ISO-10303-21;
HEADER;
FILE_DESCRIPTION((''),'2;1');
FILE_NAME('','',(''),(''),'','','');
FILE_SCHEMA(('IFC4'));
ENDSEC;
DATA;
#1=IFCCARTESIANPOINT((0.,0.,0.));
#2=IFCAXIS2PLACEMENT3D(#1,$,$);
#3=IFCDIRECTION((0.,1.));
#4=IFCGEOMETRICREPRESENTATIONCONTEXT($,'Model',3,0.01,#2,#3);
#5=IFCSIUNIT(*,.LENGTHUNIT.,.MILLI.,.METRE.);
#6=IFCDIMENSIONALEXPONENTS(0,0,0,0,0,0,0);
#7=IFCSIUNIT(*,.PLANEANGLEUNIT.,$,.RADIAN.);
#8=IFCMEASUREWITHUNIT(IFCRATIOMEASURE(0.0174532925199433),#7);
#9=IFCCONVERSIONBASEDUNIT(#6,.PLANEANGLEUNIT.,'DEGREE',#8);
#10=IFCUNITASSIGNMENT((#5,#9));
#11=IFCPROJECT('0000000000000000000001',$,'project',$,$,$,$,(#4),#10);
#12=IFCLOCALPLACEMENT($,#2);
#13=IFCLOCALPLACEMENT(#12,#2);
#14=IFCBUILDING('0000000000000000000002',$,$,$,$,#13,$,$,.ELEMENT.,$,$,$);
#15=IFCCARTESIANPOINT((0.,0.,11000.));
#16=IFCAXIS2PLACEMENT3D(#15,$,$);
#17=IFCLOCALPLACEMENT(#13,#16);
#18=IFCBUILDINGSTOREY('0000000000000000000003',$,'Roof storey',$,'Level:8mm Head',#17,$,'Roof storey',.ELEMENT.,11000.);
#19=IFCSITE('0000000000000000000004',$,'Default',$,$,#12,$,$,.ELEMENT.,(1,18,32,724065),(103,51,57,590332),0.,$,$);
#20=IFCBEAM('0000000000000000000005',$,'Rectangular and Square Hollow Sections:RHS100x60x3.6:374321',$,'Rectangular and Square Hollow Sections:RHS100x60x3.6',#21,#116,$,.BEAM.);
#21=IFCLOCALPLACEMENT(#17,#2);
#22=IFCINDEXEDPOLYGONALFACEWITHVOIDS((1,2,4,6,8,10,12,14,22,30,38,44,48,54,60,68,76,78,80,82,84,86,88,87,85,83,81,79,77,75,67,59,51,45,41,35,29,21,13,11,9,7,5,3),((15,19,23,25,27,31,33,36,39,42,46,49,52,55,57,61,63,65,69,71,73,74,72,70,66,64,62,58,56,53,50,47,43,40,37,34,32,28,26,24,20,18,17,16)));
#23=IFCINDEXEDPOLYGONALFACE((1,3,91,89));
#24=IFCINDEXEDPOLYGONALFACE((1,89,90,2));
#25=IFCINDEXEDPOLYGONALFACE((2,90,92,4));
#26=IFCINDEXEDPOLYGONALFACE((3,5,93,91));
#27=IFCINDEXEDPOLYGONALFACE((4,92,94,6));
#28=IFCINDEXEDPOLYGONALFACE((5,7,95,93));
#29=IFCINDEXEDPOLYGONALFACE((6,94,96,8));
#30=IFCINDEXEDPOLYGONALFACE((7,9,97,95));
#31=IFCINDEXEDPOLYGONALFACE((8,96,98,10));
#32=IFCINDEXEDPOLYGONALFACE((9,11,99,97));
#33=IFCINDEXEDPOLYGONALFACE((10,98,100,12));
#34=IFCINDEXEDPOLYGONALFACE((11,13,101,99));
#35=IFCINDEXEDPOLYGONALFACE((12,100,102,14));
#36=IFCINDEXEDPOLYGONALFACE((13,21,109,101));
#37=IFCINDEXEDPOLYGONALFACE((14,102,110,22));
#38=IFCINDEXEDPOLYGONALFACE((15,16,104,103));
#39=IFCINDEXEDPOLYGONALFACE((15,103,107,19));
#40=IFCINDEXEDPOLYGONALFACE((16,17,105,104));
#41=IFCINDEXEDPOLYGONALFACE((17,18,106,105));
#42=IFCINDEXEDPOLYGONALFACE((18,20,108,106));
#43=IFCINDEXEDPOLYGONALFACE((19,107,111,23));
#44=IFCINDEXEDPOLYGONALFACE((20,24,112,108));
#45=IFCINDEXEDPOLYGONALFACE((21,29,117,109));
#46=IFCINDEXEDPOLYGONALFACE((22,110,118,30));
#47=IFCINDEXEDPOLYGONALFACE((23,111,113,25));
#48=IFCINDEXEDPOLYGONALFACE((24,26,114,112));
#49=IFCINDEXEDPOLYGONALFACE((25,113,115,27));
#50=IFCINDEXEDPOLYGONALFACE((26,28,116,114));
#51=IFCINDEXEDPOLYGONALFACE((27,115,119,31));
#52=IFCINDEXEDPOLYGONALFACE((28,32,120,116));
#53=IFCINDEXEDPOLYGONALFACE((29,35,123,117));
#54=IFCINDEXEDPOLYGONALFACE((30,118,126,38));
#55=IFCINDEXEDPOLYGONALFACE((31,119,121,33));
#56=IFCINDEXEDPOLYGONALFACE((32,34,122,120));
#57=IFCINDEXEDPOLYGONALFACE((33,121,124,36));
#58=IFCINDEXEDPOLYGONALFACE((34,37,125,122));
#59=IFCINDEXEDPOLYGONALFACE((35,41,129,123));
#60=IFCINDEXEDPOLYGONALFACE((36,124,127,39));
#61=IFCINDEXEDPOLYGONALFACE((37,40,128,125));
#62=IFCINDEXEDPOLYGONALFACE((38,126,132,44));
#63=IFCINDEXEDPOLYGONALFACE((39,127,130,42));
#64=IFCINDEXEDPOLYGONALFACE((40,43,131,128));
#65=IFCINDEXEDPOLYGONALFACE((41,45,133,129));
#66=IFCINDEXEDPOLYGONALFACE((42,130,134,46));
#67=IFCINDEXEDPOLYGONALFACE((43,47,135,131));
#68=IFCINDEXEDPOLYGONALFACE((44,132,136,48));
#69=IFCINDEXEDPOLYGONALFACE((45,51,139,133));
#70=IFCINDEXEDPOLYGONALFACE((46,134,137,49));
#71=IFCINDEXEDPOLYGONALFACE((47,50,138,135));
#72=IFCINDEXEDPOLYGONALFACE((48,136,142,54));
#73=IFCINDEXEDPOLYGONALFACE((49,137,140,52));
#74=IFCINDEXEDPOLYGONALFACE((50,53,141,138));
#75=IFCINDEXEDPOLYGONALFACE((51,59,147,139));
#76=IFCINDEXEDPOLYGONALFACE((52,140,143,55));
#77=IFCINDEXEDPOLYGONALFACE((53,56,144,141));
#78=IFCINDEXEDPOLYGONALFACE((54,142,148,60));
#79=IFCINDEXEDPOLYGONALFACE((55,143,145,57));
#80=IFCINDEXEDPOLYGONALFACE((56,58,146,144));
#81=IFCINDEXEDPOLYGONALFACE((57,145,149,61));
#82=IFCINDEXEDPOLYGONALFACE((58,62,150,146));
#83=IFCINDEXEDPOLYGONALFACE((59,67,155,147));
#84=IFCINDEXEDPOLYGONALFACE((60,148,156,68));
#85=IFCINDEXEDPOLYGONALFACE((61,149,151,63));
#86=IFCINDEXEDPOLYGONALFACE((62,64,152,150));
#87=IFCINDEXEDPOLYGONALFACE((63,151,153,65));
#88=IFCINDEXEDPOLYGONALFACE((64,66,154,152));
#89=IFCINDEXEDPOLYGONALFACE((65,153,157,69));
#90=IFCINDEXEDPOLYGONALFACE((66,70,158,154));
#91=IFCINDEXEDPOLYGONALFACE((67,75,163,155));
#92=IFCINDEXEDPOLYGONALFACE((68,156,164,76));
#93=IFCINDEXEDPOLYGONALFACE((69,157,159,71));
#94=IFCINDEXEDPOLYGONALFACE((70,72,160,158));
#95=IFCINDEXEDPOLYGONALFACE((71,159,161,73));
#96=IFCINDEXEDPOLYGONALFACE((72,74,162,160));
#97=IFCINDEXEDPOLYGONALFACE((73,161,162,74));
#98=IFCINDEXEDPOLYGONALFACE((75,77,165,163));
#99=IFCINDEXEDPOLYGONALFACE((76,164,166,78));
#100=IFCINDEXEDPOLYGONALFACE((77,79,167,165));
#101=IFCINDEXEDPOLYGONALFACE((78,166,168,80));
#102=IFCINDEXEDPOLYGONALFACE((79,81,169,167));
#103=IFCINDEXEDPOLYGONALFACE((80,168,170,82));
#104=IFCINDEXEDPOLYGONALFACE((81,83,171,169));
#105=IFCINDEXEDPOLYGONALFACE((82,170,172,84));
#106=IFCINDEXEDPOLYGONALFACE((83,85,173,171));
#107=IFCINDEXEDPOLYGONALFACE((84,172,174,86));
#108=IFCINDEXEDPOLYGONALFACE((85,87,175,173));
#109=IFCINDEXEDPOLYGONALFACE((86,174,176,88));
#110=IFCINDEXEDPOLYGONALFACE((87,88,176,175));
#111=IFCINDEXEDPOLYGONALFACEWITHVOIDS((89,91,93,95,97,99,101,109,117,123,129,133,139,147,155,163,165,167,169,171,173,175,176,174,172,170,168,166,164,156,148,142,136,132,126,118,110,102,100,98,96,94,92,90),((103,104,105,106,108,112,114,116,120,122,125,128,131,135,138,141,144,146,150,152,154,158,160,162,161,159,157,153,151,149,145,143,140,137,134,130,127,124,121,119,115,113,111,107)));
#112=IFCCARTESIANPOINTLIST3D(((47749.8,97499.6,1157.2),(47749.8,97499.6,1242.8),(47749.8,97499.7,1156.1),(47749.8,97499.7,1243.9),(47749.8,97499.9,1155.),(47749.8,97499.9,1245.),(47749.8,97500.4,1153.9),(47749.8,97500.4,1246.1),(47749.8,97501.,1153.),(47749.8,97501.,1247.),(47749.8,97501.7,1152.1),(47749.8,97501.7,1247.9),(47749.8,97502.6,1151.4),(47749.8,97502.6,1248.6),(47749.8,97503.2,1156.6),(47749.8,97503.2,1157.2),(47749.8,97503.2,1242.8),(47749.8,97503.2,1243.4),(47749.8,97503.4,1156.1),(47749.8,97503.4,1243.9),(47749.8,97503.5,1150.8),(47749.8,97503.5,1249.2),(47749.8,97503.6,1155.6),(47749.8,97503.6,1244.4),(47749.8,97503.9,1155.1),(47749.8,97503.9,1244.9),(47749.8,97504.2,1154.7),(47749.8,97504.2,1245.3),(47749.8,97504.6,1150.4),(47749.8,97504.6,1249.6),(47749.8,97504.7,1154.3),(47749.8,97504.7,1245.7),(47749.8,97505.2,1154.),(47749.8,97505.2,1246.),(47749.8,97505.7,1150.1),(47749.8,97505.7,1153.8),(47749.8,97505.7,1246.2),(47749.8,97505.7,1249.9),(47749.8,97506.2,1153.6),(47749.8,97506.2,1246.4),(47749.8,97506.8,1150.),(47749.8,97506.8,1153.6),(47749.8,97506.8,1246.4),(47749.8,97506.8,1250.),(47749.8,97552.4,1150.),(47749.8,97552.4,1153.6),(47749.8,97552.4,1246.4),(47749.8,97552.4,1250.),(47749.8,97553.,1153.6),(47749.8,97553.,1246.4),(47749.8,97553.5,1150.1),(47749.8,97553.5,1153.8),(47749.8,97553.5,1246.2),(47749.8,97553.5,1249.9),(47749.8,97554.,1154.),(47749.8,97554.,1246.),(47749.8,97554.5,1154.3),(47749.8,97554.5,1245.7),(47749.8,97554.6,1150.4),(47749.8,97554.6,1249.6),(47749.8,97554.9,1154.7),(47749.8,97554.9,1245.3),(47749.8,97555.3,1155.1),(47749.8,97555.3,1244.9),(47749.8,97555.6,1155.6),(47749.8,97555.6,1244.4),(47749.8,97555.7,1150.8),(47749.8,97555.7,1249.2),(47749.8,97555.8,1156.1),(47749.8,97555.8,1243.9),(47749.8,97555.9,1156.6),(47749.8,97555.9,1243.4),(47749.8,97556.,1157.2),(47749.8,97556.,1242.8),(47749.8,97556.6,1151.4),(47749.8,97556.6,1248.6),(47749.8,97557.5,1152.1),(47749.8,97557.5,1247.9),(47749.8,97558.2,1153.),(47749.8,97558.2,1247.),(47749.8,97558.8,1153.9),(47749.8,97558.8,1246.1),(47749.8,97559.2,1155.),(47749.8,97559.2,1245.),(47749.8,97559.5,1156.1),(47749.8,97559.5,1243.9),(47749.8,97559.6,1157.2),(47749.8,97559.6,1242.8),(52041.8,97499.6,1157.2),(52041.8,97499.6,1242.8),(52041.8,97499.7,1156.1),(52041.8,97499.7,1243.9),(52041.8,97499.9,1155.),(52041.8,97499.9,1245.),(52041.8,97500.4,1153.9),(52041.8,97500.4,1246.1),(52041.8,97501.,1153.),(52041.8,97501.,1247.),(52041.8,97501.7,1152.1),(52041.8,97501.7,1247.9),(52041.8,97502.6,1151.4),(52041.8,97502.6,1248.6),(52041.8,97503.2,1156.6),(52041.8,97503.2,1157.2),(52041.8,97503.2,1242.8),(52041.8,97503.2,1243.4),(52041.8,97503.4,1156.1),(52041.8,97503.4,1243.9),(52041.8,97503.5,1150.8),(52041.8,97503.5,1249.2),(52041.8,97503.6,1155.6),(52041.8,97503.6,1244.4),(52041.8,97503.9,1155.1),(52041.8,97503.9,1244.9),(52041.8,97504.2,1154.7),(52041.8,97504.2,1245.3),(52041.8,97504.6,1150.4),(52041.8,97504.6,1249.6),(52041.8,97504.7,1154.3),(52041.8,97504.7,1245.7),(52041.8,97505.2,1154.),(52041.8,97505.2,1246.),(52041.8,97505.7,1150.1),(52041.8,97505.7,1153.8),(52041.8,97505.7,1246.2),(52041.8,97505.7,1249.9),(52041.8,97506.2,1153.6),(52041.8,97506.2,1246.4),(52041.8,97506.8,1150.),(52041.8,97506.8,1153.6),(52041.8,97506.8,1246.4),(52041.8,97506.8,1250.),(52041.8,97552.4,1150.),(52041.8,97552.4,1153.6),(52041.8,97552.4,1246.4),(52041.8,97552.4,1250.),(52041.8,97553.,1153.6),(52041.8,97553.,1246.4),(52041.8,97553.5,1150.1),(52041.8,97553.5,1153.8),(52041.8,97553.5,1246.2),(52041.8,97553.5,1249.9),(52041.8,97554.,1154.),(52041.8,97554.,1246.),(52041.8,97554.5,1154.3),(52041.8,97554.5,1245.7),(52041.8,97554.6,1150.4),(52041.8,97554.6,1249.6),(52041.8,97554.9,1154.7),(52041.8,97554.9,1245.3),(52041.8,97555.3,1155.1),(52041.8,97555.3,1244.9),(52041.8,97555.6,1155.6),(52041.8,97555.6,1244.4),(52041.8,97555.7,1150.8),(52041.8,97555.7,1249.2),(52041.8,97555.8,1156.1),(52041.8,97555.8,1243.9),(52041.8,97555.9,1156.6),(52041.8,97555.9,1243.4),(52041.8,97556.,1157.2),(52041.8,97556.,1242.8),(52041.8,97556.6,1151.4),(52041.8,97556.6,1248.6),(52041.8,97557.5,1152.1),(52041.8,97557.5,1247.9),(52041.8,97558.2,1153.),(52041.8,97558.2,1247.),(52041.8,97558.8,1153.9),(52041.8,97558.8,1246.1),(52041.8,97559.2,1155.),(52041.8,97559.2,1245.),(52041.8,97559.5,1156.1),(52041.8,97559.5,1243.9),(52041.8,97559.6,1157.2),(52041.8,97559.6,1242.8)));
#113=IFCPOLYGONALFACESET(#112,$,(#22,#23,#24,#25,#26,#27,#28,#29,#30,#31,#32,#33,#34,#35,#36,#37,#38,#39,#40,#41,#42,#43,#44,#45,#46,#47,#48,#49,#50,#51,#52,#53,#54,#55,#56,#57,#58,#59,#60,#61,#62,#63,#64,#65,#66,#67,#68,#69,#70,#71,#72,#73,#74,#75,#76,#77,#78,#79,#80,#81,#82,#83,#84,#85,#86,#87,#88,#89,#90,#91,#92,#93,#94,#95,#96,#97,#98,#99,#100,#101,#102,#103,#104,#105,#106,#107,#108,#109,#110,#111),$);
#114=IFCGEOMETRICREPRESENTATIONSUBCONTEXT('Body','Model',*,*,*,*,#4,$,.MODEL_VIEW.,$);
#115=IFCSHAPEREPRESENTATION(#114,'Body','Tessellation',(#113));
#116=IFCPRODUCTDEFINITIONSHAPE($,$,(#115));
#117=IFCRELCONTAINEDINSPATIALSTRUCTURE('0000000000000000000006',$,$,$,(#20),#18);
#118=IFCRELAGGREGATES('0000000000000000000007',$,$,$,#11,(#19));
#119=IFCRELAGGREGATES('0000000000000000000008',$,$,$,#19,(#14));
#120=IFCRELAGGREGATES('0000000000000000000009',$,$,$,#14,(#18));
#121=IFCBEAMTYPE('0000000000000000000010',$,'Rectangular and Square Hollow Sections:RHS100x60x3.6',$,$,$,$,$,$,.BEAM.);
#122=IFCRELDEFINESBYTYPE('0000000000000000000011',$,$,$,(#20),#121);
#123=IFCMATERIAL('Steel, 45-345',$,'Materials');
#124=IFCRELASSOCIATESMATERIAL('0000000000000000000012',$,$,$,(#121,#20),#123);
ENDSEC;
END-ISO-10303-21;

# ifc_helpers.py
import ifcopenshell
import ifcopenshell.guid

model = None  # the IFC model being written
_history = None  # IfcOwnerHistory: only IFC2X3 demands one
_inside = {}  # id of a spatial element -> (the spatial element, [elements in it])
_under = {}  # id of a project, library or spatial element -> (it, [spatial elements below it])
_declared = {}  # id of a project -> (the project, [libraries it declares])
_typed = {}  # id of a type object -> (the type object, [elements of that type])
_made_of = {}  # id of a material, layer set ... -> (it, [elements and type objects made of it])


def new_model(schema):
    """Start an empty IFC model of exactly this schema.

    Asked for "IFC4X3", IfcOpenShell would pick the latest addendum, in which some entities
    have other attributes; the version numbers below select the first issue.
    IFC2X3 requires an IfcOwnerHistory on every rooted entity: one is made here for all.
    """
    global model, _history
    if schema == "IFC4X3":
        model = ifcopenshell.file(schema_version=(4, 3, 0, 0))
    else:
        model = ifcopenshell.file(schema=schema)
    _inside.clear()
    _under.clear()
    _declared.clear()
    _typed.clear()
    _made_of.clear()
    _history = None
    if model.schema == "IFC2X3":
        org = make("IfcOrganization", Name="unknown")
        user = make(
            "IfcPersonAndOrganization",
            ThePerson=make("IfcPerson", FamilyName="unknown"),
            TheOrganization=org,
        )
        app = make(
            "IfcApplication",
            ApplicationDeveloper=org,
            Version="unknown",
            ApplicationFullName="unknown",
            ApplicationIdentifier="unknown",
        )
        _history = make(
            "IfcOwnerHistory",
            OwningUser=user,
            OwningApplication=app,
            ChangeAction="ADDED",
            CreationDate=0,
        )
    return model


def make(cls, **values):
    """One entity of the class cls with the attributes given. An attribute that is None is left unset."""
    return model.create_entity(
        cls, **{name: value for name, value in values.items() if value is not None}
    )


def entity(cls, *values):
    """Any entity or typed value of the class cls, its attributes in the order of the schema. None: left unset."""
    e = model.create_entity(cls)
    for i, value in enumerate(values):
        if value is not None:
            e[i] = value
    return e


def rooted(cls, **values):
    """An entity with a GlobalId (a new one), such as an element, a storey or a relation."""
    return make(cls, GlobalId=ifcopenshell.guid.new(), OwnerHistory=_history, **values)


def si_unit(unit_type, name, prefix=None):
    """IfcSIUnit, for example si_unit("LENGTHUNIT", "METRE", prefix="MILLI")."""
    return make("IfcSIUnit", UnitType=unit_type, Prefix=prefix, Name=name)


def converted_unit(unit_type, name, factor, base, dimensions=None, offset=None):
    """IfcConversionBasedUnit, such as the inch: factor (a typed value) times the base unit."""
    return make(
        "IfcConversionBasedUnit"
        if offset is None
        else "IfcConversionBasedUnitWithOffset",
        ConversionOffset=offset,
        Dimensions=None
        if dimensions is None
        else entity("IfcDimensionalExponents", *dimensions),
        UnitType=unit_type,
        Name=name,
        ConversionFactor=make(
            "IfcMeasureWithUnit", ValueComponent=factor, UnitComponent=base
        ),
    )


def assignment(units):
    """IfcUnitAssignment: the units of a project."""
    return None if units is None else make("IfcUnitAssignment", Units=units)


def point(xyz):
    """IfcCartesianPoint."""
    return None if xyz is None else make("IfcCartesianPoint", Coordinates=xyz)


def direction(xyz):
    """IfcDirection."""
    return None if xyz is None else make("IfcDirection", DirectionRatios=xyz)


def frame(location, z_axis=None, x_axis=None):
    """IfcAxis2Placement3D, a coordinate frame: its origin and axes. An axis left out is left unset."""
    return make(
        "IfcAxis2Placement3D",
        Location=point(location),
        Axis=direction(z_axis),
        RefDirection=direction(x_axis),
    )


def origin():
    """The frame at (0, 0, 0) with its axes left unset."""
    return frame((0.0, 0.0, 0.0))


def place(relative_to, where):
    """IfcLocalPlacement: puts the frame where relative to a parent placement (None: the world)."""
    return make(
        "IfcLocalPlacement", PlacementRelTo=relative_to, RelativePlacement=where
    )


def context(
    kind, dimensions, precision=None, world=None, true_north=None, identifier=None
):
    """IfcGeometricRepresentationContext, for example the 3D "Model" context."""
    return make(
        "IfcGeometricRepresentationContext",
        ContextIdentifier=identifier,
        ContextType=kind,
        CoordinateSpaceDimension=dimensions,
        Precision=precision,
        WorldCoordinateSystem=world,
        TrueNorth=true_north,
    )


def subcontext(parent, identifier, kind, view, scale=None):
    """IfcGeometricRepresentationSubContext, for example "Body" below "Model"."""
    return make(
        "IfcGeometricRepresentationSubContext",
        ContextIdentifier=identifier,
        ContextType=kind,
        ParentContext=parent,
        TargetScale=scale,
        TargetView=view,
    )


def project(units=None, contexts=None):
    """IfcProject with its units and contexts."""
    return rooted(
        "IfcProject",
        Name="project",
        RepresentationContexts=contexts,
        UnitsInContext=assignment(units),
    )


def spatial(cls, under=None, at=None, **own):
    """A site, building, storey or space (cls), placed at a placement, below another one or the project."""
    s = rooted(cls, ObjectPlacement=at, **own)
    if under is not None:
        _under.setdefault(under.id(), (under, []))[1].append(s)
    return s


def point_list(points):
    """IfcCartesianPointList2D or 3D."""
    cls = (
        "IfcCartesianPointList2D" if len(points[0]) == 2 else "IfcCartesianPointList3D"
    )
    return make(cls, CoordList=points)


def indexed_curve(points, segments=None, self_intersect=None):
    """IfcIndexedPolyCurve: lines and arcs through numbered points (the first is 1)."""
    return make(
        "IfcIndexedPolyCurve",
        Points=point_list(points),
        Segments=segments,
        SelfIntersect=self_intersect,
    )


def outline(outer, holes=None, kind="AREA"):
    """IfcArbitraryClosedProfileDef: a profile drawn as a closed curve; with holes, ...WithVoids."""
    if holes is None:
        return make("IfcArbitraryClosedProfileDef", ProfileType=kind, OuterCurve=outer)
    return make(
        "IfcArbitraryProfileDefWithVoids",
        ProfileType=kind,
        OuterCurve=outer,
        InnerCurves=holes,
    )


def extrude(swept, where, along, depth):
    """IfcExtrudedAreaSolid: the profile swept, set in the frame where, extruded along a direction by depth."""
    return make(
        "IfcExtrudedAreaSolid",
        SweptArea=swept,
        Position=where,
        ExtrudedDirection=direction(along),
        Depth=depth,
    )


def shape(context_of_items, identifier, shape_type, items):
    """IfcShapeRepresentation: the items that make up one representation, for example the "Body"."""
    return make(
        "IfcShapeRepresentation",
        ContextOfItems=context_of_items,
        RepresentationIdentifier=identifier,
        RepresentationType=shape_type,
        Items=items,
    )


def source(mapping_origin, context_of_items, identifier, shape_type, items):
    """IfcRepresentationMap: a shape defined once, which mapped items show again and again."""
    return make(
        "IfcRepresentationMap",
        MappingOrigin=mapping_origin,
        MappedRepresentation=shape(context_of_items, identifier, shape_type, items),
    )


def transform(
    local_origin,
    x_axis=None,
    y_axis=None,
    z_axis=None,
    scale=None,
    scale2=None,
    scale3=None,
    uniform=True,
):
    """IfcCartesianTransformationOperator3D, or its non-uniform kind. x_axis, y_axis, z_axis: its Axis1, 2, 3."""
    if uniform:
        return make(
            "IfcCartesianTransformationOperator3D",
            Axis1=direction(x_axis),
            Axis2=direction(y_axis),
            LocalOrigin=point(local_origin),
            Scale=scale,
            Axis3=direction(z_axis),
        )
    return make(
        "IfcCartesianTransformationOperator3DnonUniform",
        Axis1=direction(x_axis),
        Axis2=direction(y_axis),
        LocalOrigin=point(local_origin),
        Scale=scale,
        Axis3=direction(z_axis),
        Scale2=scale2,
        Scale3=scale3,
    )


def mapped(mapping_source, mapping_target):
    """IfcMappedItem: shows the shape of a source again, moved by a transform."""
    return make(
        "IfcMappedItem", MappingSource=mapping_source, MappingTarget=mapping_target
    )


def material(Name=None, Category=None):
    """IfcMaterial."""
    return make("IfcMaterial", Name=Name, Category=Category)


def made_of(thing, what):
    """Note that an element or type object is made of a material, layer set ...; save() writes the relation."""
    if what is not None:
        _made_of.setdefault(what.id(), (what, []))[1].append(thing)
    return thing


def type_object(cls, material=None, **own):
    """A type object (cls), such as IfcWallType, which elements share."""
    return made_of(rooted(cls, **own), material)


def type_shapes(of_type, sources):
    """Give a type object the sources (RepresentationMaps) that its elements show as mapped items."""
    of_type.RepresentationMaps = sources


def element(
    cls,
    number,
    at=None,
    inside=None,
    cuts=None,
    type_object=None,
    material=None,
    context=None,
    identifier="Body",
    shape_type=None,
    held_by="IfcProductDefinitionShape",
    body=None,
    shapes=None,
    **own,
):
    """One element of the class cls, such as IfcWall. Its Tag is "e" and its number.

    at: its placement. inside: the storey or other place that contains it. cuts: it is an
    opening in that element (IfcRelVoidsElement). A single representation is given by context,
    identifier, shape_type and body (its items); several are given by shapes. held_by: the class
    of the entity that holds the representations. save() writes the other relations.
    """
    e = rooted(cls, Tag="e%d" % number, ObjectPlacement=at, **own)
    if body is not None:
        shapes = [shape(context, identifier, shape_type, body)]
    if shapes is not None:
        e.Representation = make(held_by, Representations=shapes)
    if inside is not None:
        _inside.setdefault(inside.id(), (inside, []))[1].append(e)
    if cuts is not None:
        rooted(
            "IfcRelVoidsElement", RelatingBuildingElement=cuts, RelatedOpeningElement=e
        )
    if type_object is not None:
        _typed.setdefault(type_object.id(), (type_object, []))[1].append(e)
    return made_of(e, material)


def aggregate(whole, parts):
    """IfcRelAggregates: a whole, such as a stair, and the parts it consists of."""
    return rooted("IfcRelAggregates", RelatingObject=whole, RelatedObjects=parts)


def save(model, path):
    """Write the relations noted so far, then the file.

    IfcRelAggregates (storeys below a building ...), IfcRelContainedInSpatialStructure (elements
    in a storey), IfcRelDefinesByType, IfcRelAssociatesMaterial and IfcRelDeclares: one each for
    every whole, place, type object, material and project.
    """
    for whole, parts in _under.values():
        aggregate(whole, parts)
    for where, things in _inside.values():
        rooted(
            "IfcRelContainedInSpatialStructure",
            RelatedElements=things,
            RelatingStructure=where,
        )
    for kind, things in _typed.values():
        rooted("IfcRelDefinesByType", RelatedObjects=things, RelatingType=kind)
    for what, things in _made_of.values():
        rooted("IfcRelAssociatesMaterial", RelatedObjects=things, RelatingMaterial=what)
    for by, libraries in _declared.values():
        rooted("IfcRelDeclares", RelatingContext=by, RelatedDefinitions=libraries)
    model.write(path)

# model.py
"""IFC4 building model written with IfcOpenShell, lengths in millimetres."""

from ifc_helpers import new_model, entity, si_unit, converted_unit, direction, frame, origin, place, context, subcontext, project, spatial, indexed_curve, outline, extrude, source, transform, mapped, material, type_object, type_shapes, element, save


model = new_model("IFC4")

# Units and contexts
model_context = context("Model", 3, precision=0.01, world=origin(), true_north=direction((0.0, 1.0)))
body_context = subcontext(model_context, "Body", "Model", "MODEL_VIEW")
ifc_project = project(units=[si_unit("LENGTHUNIT", "METRE", prefix="MILLI"), converted_unit("PLANEANGLEUNIT", "DEGREE", entity("IfcRatioMeasure", 0.0174532925199433), si_unit("PLANEANGLEUNIT", "RADIAN"), dimensions=[0, 0, 0, 0, 0, 0, 0])], contexts=[model_context])

# Site, building, storey
site_placement = place(None, origin())
site = spatial("IfcSite", under=ifc_project, at=site_placement, Name="Default", CompositionType="ELEMENT", RefLatitude=(1, 18, 32, 724065), RefLongitude=(103, 51, 57, 590332), RefElevation=0.0)
building_placement = place(site_placement, origin())
building = spatial("IfcBuilding", under=site, at=building_placement, CompositionType="ELEMENT")
storey_placement = place(building_placement, frame((0.0, 0.0, 11000.0)))
storey = spatial("IfcBuildingStorey", under=building, at=storey_placement, Name="Roof storey", ObjectType="Level:8mm Head", LongName="Roof storey", CompositionType="ELEMENT", Elevation=11000.0)

# Shared definitions
ifc_material = material(Name="Steel, 45-345", Category="Materials")

# Beam
beam_type_1 = type_object("IfcBeamType", Name="Rectangular and Square Hollow Sections:RHS100x60x3.6", PredefinedType="BEAM", material=ifc_material)
shared_shape_1 = source(origin(), body_context, "Body", "SweptSolid", [
    extrude(outline(indexed_curve([(-30.0, -42.8), (-29.9, -43.9), (-29.6, -45.0), (-29.2, -46.1), (-28.6, -47.0), (-27.9, -47.9), (-27.0, -48.6), (-26.1, -49.2), (-25.0, -49.6), (-23.9, -49.9), (-22.8, -50.0), (22.8, -50.0), (23.9, -49.9), (25.0, -49.6), (26.1, -49.2), (27.0, -48.6), (27.9, -47.9), (28.6, -47.0), (29.2, -46.1), (29.6, -45.0), (29.9, -43.9), (30.0, -42.8), (30.0, 42.8), (29.9, 43.9), (29.6, 45.0), (29.2, 46.1), (28.6, 47.0), (27.9, 47.9), (27.0, 48.6), (26.1, 49.2), (25.0, 49.6), (23.9, 49.9), (22.8, 50.0), (-22.8, 50.0), (-23.9, 49.9), (-25.0, 49.6), (-26.1, 49.2), (-27.0, 48.6), (-27.9, 47.9), (-28.6, 47.0), (-29.2, 46.1), (-29.6, 45.0), (-29.9, 43.9), (-30.0, 42.8), (-30.0, -42.8)], self_intersect=False), holes=[indexed_curve([(22.8, -46.4), (-22.8, -46.4), (-23.4, -46.4), (-23.9, -46.2), (-24.4, -46.0), (-24.9, -45.7), (-25.3, -45.3), (-25.7, -44.9), (-26.0, -44.4), (-26.2, -43.9), (-26.4, -43.4), (-26.4, -42.8), (-26.4, 42.8), (-26.4, 43.4), (-26.2, 43.9), (-26.0, 44.4), (-25.7, 44.9), (-25.3, 45.3), (-24.9, 45.7), (-24.4, 46.0), (-23.9, 46.2), (-23.4, 46.4), (-22.8, 46.4), (22.8, 46.4), (23.4, 46.4), (23.9, 46.2), (24.4, 46.0), (24.9, 45.7), (25.3, 45.3), (25.7, 44.9), (26.0, 44.4), (26.2, 43.9), (26.4, 43.4), (26.4, 42.8), (26.4, -42.8), (26.4, -43.4), (26.2, -43.9), (26.0, -44.4), (25.7, -44.9), (25.3, -45.3), (24.9, -45.7), (24.4, -46.0), (23.9, -46.2), (23.4, -46.4), (22.8, -46.4)], self_intersect=False)]), frame((-2139.5, 0.0, 0.0), z_axis=(1.0, 0.0, 0.0), x_axis=(0.0, -1.0, 0.0)), (0.0, 0.0, 1.0), 4292.0),
])
type_shapes(beam_type_1, [shared_shape_1])
for number, where, name in (
    (1, (49889.3, 97529.6, 1200.0), "Rectangular and Square Hollow Sections:RHS100x60x3.6:374321"),
):
    element("IfcBeam", number, at=place(storey_placement, frame(where)), inside=storey, type_object=beam_type_1, material=ifc_material, Name=name, ObjectType="Rectangular and Square Hollow Sections:RHS100x60x3.6", PredefinedType="BEAM", context=body_context, shape_type="MappedRepresentation", body=[
        mapped(shared_shape_1, transform((0.0, 0.0, 0.0), scale=1.0)),
    ])

save(model, "model.ifc")
